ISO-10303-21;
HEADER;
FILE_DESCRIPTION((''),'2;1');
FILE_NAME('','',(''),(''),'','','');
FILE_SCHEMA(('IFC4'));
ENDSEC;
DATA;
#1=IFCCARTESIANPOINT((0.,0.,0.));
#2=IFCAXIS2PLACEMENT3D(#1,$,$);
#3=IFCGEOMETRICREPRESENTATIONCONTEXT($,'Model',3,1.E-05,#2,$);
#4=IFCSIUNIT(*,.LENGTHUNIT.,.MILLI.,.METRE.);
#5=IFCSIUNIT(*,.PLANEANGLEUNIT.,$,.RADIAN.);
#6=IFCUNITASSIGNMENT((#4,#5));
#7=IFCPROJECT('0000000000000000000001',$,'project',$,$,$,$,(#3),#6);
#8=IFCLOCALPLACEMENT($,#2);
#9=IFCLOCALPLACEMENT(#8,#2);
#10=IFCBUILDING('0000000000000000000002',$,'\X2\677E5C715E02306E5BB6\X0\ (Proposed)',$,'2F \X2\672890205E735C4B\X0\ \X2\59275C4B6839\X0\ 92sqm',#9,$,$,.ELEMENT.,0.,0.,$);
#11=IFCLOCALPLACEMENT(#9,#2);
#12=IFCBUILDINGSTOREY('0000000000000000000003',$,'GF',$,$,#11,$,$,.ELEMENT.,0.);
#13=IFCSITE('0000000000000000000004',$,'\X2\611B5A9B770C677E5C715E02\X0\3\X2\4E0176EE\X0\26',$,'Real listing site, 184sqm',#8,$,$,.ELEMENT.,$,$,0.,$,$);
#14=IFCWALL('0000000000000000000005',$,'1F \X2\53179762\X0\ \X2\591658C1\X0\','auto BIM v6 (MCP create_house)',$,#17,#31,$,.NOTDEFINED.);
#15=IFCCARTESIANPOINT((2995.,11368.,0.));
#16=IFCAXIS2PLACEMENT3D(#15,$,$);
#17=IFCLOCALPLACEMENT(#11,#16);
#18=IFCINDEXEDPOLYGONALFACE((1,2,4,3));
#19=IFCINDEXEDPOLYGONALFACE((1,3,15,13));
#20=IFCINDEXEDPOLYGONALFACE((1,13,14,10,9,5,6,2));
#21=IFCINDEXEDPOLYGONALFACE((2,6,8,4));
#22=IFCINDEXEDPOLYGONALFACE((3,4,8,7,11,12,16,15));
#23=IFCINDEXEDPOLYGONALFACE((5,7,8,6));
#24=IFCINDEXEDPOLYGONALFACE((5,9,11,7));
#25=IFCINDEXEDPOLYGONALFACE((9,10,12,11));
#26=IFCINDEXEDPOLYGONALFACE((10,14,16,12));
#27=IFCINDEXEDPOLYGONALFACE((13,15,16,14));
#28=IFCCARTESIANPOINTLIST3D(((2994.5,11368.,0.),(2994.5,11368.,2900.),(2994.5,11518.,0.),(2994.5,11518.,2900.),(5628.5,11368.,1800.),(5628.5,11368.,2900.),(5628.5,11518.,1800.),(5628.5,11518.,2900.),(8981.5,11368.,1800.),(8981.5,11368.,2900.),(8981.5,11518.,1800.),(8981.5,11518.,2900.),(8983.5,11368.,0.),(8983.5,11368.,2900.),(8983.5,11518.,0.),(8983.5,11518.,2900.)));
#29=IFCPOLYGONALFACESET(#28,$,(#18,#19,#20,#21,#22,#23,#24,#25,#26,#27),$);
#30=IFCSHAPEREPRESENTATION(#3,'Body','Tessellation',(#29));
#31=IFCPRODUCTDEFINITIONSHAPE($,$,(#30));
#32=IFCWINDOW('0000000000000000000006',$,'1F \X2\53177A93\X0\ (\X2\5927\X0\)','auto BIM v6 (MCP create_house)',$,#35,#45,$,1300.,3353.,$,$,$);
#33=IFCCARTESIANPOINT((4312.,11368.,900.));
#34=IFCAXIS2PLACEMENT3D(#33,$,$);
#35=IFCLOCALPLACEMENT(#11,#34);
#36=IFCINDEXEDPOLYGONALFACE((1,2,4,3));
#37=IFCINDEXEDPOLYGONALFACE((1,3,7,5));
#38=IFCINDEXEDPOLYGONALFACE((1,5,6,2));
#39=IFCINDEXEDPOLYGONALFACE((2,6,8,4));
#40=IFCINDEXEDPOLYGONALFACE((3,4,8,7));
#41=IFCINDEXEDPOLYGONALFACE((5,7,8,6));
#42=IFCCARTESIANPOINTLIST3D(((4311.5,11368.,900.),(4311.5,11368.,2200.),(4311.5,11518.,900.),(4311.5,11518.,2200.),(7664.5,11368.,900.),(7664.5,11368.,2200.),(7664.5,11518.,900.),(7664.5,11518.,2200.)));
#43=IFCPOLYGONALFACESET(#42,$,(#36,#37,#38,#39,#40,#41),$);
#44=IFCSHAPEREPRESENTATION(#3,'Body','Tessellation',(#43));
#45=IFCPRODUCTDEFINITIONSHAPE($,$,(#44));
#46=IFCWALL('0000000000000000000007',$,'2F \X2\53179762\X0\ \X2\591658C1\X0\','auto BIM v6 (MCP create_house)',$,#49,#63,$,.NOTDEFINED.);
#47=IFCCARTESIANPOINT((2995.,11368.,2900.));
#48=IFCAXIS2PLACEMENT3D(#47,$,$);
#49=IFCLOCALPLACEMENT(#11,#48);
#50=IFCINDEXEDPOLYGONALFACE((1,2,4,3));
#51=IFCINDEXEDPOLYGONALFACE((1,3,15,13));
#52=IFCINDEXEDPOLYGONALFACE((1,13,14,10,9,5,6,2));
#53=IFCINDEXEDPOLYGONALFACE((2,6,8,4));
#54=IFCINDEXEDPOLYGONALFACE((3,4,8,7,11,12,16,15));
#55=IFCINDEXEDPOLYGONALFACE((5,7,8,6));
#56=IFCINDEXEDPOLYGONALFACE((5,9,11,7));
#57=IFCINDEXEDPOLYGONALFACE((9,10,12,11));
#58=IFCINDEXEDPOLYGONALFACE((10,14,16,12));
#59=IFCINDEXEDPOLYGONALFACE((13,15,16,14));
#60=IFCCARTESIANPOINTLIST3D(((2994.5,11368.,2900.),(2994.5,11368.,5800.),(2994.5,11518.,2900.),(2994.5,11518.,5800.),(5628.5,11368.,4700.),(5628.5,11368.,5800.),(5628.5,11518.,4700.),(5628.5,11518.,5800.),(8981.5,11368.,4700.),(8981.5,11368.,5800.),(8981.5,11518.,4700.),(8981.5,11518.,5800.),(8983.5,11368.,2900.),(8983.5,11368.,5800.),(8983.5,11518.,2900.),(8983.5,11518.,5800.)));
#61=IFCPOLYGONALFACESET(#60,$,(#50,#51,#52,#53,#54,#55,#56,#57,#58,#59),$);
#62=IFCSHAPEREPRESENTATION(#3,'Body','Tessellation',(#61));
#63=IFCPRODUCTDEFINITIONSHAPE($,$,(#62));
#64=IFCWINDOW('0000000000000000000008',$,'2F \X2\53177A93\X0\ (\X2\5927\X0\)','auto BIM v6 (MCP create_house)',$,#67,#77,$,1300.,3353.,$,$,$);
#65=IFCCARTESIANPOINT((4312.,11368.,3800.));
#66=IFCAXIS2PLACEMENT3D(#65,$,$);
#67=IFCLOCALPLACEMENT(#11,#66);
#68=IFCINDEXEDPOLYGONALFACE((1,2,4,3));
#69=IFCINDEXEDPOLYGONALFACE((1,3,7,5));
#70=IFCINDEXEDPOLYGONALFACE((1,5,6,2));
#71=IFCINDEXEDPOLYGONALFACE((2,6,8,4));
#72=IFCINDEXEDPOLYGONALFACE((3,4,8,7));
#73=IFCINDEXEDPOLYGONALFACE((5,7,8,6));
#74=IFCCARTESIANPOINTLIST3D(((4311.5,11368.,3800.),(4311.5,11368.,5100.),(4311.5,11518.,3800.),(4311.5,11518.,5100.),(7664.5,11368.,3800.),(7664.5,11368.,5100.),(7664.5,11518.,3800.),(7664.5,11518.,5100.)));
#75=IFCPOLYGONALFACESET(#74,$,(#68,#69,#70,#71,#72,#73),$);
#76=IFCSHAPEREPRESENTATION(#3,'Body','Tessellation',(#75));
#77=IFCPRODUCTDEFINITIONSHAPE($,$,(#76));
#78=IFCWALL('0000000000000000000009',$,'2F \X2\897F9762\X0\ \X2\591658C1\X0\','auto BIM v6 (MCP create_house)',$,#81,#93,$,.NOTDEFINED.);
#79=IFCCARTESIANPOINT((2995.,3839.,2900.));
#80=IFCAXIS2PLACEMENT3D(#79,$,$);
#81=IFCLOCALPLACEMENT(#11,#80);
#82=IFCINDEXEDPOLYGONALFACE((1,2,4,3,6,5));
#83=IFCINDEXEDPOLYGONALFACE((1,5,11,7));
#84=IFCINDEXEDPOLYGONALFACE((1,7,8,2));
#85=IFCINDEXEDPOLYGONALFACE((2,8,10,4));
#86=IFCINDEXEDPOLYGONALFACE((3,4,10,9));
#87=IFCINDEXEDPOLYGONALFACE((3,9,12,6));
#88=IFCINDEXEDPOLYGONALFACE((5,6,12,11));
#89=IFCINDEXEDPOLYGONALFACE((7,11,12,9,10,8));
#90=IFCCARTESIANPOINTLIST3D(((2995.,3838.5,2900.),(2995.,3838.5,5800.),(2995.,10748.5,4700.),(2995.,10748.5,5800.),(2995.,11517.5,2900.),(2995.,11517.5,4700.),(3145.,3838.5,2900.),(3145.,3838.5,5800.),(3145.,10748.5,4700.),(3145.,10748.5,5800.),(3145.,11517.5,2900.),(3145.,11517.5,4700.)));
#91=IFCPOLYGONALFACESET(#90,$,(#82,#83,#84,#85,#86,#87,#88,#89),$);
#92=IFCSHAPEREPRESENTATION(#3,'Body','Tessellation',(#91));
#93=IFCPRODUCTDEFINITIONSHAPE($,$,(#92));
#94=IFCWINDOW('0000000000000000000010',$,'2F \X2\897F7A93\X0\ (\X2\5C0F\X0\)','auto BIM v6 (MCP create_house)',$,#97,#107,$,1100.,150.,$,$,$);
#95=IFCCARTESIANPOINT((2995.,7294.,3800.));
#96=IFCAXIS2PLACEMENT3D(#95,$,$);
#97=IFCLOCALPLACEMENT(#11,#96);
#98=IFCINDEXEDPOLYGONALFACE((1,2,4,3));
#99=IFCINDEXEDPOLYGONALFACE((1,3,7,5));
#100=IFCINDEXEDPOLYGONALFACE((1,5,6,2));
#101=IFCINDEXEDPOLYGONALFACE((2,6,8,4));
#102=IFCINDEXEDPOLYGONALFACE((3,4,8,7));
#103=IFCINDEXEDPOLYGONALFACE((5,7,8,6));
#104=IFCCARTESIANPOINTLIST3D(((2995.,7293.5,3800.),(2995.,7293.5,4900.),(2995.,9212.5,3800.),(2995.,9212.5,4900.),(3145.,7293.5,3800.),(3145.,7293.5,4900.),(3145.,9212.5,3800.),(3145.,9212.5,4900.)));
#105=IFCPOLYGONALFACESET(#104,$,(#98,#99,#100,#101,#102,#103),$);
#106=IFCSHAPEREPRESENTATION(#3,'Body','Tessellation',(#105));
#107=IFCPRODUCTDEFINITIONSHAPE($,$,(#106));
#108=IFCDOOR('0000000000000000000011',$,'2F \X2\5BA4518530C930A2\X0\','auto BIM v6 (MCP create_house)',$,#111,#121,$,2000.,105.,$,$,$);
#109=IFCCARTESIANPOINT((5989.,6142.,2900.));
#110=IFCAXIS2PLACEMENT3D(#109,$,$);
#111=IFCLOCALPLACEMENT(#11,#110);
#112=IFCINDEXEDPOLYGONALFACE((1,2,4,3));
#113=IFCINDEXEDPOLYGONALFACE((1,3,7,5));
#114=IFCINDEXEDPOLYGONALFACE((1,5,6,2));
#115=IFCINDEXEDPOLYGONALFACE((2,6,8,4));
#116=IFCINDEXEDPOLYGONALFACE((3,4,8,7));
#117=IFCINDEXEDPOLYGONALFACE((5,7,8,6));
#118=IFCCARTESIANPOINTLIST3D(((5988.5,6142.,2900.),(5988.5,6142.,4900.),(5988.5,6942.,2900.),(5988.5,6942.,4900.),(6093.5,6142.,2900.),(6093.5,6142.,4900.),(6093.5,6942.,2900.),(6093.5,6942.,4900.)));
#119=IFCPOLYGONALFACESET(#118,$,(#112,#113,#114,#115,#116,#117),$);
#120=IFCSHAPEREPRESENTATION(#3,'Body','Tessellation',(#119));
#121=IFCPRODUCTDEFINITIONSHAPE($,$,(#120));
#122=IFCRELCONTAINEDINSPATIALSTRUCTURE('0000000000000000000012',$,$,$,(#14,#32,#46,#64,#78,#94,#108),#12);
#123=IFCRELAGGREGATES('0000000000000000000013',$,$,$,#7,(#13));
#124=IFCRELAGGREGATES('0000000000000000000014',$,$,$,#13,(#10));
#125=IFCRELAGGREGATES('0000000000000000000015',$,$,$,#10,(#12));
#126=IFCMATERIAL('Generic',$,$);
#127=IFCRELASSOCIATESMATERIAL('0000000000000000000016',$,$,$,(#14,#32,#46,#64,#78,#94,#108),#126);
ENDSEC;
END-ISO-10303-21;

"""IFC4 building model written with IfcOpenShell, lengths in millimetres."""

from ifc_helpers import new_model, si_unit, frame, frame_2d, origin, place, context, project, spatial, rectangle, extrude, material, element, fill, save


model = new_model("IFC4")

# Units and contexts
model_context = context("Model", 3, precision=1e-05, world=origin())
ifc_project = project(units=[si_unit("LENGTHUNIT", "METRE", prefix="MILLI"), si_unit("PLANEANGLEUNIT", "RADIAN")], contexts=[model_context])

# Site, building, storey
site_placement = place(None, origin())
site = spatial("IfcSite", under=ifc_project, at=site_placement, Name="愛媛県松山市3丁目26", ObjectType="Real listing site, 184sqm", CompositionType="ELEMENT", RefElevation=0.0)
building_placement = place(site_placement, origin())
building = spatial("IfcBuilding", under=site, at=building_placement, Name="松山市の家 (Proposed)", ObjectType="2F 木造平屋 大屋根 92sqm", CompositionType="ELEMENT", ElevationOfRefHeight=0.0, ElevationOfTerrain=0.0)
storey_placement = place(building_placement, origin())
storey = spatial("IfcBuildingStorey", under=building, at=storey_placement, Name="GF", CompositionType="ELEMENT", Elevation=0.0)

# Wall, opening, window
ifc_material = material(Name="Generic")
wall_1_placement = place(storey_placement, frame((2995.0, 11368.0, 0.0)))
wall_1 = element("IfcWall", 1, at=wall_1_placement, inside=storey, material=ifc_material, Name="1F 北面 外壁", Description="auto BIM v6 (MCP create_house)", PredefinedType="NOTDEFINED", context=model_context, shape_type="SweptSolid", body=[
    extrude(rectangle(XDim=5989.0, YDim=150.0, at=frame_2d((2994.0, 75.0))), frame((2995.0, 11368.0, 0.0)), (0.0, 0.0, 1.0), 2900.0),
])
opening_1_placement = place(storey_placement, frame((4312.0, 11368.0, 900.0)))
opening_1 = element("IfcOpeningElement", 2, at=opening_1_placement, cuts=wall_1, PredefinedType="NOTDEFINED", context=model_context, shape_type="SweptSolid", body=[
    extrude(rectangle(XDim=3353.0, YDim=150.0, at=frame_2d((1676.0, 75.0))), frame((4312.0, 11368.0, 900.0)), (0.0, 0.0, 1.0), 1300.0),
])
window_1_placement = place(storey_placement, frame((4312.0, 11368.0, 900.0)))
window_1 = element("IfcWindow", 3, at=window_1_placement, inside=storey, material=ifc_material, Name="1F 北窓 (大)", Description="auto BIM v6 (MCP create_house)", OverallHeight=1300.0, OverallWidth=3353.0, context=model_context, shape_type="SweptSolid", body=[
    extrude(rectangle(XDim=3353.0, YDim=150.0, at=frame_2d((1676.0, 75.0))), frame((4312.0, 11368.0, 900.0)), (0.0, 0.0, 1.0), 1300.0),
])
fill(opening_1, window_1)

# Walls, openings, windows
wall_2_placement = place(storey_placement, frame((2995.0, 11368.0, 2900.0)))
wall_2 = element("IfcWall", 4, at=wall_2_placement, inside=storey, material=ifc_material, Name="2F 北面 外壁", Description="auto BIM v6 (MCP create_house)", PredefinedType="NOTDEFINED", context=model_context, shape_type="SweptSolid", body=[
    extrude(rectangle(XDim=5989.0, YDim=150.0, at=frame_2d((2994.0, 75.0))), frame((2995.0, 11368.0, 2900.0)), (0.0, 0.0, 1.0), 2900.0),
])
opening_2_placement = place(storey_placement, frame((4312.0, 11368.0, 3800.0)))
opening_2 = element("IfcOpeningElement", 5, at=opening_2_placement, cuts=wall_2, PredefinedType="NOTDEFINED", context=model_context, shape_type="SweptSolid", body=[
    extrude(rectangle(XDim=3353.0, YDim=150.0, at=frame_2d((1676.0, 75.0))), frame((4312.0, 11368.0, 3800.0)), (0.0, 0.0, 1.0), 1300.0),
])
window_2_placement = place(storey_placement, frame((4312.0, 11368.0, 3800.0)))
window_2 = element("IfcWindow", 6, at=window_2_placement, inside=storey, material=ifc_material, Name="2F 北窓 (大)", Description="auto BIM v6 (MCP create_house)", OverallHeight=1300.0, OverallWidth=3353.0, context=model_context, shape_type="SweptSolid", body=[
    extrude(rectangle(XDim=3353.0, YDim=150.0, at=frame_2d((1676.0, 75.0))), frame((4312.0, 11368.0, 3800.0)), (0.0, 0.0, 1.0), 1300.0),
])
fill(opening_2, window_2)
wall_3_placement = place(storey_placement, frame((2995.0, 3839.0, 2900.0)))
wall_3 = element("IfcWall", 7, at=wall_3_placement, inside=storey, material=ifc_material, Name="2F 西面 外壁", Description="auto BIM v6 (MCP create_house)", PredefinedType="NOTDEFINED", context=model_context, shape_type="SweptSolid", body=[
    extrude(rectangle(XDim=150.0, YDim=7679.0, at=frame_2d((75.0, 3839.0))), frame((2995.0, 3839.0, 2900.0)), (0.0, 0.0, 1.0), 2900.0),
])
opening_3_placement = place(storey_placement, frame((2995.0, 7294.0, 3800.0)))
opening_3 = element("IfcOpeningElement", 8, at=opening_3_placement, cuts=wall_3, PredefinedType="NOTDEFINED", context=model_context, shape_type="SweptSolid", body=[
    extrude(rectangle(XDim=150.0, YDim=1919.0, at=frame_2d((75.0, 959.0))), frame((2995.0, 7294.0, 3800.0)), (0.0, 0.0, 1.0), 1100.0),
])
window_3_placement = place(storey_placement, frame((2995.0, 7294.0, 3800.0)))
window_3 = element("IfcWindow", 9, at=window_3_placement, inside=storey, material=ifc_material, Name="2F 西窓 (小)", Description="auto BIM v6 (MCP create_house)", OverallHeight=1100.0, OverallWidth=150.0, context=model_context, shape_type="SweptSolid", body=[
    extrude(rectangle(XDim=150.0, YDim=1919.0, at=frame_2d((75.0, 959.0))), frame((2995.0, 7294.0, 3800.0)), (0.0, 0.0, 1.0), 1100.0),
])
fill(opening_3, window_3)

# Door
door_placement = place(storey_placement, frame((5989.0, 6142.0, 2900.0)))
element("IfcDoor", 10, at=door_placement, inside=storey, material=ifc_material, Name="2F 室内ドア", Description="auto BIM v6 (MCP create_house)", OverallHeight=2000.0, OverallWidth=105.0, context=model_context, shape_type="SweptSolid", body=[
    extrude(rectangle(XDim=105.0, YDim=800.0, at=frame_2d((52.0, 400.0))), frame((5989.0, 6142.0, 2900.0)), (0.0, 0.0, 1.0), 2000.0),
])

save(model, "model.ifc")
